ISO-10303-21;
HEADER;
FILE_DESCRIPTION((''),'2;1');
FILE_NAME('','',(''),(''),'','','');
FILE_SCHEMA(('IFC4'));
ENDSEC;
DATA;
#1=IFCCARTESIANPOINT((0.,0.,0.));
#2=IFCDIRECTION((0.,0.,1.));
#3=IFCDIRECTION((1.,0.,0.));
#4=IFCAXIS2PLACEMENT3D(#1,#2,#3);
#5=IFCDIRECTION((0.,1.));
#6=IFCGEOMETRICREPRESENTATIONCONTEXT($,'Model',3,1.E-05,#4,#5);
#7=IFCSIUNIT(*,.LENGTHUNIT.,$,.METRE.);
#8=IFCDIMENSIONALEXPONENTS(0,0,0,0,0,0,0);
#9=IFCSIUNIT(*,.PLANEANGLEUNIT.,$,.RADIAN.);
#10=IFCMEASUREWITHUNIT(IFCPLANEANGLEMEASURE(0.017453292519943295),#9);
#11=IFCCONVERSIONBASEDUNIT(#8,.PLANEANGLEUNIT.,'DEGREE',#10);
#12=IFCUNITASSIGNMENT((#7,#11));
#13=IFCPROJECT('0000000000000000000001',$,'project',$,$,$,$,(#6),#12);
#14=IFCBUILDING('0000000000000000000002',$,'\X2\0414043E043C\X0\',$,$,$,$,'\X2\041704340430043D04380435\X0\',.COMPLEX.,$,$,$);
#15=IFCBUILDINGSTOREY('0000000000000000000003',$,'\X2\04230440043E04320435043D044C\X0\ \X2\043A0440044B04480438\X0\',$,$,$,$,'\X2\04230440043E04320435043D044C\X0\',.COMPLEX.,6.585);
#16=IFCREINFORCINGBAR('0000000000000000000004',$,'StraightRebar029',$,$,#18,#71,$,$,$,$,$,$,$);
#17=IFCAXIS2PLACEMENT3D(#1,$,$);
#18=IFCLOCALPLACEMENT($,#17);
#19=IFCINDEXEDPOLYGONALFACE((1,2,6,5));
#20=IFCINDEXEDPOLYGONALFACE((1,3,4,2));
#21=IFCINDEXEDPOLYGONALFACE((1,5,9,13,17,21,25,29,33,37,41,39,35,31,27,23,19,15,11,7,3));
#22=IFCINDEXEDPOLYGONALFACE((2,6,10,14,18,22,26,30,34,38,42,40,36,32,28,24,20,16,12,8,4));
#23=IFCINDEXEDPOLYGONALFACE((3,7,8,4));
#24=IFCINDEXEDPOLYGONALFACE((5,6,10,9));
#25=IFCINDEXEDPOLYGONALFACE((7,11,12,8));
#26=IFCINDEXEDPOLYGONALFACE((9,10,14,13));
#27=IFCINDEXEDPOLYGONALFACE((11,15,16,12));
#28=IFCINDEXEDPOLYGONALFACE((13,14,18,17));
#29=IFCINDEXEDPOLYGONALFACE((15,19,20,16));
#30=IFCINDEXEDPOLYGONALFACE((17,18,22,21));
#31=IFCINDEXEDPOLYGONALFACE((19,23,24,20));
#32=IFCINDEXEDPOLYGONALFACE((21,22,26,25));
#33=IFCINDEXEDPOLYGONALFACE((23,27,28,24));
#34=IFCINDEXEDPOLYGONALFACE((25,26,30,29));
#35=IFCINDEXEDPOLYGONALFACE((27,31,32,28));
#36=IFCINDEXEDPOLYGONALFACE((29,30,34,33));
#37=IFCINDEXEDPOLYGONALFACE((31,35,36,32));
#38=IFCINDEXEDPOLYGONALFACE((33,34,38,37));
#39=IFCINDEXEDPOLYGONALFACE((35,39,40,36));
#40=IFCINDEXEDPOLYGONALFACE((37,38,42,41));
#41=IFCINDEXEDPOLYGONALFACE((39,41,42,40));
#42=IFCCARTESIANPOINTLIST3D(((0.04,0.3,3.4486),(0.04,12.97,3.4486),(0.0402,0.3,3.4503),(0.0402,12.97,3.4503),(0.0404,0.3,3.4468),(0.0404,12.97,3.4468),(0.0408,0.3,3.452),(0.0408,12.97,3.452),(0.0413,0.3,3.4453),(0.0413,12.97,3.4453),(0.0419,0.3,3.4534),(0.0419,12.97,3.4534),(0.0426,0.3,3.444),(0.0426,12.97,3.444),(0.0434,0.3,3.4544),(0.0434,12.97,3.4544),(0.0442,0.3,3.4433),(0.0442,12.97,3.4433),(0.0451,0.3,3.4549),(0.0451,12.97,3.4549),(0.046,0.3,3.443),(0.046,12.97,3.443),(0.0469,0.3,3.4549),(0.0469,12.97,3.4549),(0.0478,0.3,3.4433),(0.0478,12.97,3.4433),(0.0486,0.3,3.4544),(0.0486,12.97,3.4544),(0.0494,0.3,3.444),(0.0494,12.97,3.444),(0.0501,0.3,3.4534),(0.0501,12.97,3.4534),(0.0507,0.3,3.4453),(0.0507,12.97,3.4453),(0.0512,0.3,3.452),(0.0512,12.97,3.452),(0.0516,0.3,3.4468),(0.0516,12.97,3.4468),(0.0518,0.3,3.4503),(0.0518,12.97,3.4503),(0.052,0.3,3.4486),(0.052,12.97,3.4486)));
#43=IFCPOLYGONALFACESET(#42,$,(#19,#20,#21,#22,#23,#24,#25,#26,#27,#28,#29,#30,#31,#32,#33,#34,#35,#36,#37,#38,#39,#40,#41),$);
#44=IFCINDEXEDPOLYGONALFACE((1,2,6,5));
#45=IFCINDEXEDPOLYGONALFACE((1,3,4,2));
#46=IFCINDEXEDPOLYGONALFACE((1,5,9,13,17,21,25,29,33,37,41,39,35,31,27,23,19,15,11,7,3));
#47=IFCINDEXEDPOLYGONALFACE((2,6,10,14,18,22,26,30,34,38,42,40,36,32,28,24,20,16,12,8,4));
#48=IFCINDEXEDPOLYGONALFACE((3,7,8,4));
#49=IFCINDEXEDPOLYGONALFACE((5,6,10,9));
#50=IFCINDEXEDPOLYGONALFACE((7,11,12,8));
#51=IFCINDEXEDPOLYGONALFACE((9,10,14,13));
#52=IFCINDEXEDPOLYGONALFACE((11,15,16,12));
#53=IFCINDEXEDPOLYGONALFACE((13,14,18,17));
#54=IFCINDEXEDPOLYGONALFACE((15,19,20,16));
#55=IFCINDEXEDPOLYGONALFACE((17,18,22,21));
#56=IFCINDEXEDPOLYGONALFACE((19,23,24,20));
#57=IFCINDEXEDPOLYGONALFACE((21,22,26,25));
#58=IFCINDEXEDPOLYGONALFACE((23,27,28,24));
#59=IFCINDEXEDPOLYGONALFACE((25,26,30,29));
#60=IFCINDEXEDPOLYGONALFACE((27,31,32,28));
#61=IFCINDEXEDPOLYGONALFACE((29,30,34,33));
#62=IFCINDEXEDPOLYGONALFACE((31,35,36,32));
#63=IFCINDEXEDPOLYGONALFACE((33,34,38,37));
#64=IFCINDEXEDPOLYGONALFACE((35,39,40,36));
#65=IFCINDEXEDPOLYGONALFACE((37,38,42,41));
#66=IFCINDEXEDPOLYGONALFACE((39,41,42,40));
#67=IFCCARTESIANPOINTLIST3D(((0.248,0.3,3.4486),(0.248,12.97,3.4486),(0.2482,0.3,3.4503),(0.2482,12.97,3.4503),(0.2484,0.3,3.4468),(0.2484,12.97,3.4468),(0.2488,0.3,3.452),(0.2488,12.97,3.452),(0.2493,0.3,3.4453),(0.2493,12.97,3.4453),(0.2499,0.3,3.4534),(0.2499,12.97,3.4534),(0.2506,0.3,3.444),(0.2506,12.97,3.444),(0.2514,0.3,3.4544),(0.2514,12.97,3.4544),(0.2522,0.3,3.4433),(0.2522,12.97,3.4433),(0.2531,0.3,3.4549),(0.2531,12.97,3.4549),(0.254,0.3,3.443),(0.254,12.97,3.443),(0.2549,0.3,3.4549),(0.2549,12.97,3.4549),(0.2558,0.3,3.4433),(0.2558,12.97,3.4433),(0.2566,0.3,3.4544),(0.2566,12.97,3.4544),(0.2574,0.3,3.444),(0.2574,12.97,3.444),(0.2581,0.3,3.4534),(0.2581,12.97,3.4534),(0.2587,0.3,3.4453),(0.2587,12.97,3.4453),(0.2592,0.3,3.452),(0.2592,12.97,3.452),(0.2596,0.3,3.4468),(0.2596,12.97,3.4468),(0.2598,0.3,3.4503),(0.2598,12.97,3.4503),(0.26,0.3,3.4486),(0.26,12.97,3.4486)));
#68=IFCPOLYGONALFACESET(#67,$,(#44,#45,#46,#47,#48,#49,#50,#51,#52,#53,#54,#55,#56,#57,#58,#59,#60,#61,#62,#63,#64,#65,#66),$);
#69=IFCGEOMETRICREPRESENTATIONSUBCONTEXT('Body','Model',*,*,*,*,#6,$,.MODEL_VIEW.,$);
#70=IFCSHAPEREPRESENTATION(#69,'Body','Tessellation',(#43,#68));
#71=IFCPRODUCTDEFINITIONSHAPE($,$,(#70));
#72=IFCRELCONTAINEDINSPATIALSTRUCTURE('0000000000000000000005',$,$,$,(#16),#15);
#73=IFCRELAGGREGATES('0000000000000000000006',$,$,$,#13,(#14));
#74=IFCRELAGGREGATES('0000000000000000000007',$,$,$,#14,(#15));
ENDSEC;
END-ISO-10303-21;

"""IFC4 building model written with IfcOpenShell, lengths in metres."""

from ifc_helpers import new_model, entity, si_unit, converted_unit, direction, origin_with_axes, place, context, subcontext, project, spatial, element, save


model = new_model("IFC4")

# Units and contexts
model_context = context("Model", 3, precision=1e-05, world=origin_with_axes(), true_north=direction((0.0, 1.0)))
body_context = subcontext(model_context, "Body", "Model", "MODEL_VIEW")
ifc_project = project(units=[si_unit("LENGTHUNIT", "METRE"), converted_unit("PLANEANGLEUNIT", "DEGREE", entity("IfcPlaneAngleMeasure", 0.017453292519943295), si_unit("PLANEANGLEUNIT", "RADIAN"), dimensions=[0, 0, 0, 0, 0, 0, 0])], contexts=[model_context])

# Building, storey
building = spatial("IfcBuilding", under=ifc_project, Name="Дом", LongName="Здание", CompositionType="COMPLEX")
storey = spatial("IfcBuildingStorey", under=building, Name="Уровень крыши", LongName="Уровень", CompositionType="COMPLEX", Elevation=6.585)

# Shared definitions
placement = place(None, origin_with_axes())

# Reinforcing bar
element("IfcReinforcingBar", 1, at=placement, inside=storey, Name="StraightRebar029", context=body_context, shape_type="SweptSolid", body=[
    entity("IfcSweptDiskSolid", entity("IfcCompositeCurve", [entity("IfcCompositeCurveSegment", "CONTINUOUS", True, entity("IfcPolyline", [entity("IfcCartesianPoint", [0.046, 12.97, 3.449]), entity("IfcCartesianPoint", [0.046, 0.3, 3.449])]))], False), 0.006),
    entity("IfcSweptDiskSolid", entity("IfcCompositeCurve", [entity("IfcCompositeCurveSegment", "CONTINUOUS", True, entity("IfcPolyline", [entity("IfcCartesianPoint", [0.254, 12.97, 3.449]), entity("IfcCartesianPoint", [0.254, 0.3, 3.449])]))], False), 0.006),
])

save(model, "model.ifc")
